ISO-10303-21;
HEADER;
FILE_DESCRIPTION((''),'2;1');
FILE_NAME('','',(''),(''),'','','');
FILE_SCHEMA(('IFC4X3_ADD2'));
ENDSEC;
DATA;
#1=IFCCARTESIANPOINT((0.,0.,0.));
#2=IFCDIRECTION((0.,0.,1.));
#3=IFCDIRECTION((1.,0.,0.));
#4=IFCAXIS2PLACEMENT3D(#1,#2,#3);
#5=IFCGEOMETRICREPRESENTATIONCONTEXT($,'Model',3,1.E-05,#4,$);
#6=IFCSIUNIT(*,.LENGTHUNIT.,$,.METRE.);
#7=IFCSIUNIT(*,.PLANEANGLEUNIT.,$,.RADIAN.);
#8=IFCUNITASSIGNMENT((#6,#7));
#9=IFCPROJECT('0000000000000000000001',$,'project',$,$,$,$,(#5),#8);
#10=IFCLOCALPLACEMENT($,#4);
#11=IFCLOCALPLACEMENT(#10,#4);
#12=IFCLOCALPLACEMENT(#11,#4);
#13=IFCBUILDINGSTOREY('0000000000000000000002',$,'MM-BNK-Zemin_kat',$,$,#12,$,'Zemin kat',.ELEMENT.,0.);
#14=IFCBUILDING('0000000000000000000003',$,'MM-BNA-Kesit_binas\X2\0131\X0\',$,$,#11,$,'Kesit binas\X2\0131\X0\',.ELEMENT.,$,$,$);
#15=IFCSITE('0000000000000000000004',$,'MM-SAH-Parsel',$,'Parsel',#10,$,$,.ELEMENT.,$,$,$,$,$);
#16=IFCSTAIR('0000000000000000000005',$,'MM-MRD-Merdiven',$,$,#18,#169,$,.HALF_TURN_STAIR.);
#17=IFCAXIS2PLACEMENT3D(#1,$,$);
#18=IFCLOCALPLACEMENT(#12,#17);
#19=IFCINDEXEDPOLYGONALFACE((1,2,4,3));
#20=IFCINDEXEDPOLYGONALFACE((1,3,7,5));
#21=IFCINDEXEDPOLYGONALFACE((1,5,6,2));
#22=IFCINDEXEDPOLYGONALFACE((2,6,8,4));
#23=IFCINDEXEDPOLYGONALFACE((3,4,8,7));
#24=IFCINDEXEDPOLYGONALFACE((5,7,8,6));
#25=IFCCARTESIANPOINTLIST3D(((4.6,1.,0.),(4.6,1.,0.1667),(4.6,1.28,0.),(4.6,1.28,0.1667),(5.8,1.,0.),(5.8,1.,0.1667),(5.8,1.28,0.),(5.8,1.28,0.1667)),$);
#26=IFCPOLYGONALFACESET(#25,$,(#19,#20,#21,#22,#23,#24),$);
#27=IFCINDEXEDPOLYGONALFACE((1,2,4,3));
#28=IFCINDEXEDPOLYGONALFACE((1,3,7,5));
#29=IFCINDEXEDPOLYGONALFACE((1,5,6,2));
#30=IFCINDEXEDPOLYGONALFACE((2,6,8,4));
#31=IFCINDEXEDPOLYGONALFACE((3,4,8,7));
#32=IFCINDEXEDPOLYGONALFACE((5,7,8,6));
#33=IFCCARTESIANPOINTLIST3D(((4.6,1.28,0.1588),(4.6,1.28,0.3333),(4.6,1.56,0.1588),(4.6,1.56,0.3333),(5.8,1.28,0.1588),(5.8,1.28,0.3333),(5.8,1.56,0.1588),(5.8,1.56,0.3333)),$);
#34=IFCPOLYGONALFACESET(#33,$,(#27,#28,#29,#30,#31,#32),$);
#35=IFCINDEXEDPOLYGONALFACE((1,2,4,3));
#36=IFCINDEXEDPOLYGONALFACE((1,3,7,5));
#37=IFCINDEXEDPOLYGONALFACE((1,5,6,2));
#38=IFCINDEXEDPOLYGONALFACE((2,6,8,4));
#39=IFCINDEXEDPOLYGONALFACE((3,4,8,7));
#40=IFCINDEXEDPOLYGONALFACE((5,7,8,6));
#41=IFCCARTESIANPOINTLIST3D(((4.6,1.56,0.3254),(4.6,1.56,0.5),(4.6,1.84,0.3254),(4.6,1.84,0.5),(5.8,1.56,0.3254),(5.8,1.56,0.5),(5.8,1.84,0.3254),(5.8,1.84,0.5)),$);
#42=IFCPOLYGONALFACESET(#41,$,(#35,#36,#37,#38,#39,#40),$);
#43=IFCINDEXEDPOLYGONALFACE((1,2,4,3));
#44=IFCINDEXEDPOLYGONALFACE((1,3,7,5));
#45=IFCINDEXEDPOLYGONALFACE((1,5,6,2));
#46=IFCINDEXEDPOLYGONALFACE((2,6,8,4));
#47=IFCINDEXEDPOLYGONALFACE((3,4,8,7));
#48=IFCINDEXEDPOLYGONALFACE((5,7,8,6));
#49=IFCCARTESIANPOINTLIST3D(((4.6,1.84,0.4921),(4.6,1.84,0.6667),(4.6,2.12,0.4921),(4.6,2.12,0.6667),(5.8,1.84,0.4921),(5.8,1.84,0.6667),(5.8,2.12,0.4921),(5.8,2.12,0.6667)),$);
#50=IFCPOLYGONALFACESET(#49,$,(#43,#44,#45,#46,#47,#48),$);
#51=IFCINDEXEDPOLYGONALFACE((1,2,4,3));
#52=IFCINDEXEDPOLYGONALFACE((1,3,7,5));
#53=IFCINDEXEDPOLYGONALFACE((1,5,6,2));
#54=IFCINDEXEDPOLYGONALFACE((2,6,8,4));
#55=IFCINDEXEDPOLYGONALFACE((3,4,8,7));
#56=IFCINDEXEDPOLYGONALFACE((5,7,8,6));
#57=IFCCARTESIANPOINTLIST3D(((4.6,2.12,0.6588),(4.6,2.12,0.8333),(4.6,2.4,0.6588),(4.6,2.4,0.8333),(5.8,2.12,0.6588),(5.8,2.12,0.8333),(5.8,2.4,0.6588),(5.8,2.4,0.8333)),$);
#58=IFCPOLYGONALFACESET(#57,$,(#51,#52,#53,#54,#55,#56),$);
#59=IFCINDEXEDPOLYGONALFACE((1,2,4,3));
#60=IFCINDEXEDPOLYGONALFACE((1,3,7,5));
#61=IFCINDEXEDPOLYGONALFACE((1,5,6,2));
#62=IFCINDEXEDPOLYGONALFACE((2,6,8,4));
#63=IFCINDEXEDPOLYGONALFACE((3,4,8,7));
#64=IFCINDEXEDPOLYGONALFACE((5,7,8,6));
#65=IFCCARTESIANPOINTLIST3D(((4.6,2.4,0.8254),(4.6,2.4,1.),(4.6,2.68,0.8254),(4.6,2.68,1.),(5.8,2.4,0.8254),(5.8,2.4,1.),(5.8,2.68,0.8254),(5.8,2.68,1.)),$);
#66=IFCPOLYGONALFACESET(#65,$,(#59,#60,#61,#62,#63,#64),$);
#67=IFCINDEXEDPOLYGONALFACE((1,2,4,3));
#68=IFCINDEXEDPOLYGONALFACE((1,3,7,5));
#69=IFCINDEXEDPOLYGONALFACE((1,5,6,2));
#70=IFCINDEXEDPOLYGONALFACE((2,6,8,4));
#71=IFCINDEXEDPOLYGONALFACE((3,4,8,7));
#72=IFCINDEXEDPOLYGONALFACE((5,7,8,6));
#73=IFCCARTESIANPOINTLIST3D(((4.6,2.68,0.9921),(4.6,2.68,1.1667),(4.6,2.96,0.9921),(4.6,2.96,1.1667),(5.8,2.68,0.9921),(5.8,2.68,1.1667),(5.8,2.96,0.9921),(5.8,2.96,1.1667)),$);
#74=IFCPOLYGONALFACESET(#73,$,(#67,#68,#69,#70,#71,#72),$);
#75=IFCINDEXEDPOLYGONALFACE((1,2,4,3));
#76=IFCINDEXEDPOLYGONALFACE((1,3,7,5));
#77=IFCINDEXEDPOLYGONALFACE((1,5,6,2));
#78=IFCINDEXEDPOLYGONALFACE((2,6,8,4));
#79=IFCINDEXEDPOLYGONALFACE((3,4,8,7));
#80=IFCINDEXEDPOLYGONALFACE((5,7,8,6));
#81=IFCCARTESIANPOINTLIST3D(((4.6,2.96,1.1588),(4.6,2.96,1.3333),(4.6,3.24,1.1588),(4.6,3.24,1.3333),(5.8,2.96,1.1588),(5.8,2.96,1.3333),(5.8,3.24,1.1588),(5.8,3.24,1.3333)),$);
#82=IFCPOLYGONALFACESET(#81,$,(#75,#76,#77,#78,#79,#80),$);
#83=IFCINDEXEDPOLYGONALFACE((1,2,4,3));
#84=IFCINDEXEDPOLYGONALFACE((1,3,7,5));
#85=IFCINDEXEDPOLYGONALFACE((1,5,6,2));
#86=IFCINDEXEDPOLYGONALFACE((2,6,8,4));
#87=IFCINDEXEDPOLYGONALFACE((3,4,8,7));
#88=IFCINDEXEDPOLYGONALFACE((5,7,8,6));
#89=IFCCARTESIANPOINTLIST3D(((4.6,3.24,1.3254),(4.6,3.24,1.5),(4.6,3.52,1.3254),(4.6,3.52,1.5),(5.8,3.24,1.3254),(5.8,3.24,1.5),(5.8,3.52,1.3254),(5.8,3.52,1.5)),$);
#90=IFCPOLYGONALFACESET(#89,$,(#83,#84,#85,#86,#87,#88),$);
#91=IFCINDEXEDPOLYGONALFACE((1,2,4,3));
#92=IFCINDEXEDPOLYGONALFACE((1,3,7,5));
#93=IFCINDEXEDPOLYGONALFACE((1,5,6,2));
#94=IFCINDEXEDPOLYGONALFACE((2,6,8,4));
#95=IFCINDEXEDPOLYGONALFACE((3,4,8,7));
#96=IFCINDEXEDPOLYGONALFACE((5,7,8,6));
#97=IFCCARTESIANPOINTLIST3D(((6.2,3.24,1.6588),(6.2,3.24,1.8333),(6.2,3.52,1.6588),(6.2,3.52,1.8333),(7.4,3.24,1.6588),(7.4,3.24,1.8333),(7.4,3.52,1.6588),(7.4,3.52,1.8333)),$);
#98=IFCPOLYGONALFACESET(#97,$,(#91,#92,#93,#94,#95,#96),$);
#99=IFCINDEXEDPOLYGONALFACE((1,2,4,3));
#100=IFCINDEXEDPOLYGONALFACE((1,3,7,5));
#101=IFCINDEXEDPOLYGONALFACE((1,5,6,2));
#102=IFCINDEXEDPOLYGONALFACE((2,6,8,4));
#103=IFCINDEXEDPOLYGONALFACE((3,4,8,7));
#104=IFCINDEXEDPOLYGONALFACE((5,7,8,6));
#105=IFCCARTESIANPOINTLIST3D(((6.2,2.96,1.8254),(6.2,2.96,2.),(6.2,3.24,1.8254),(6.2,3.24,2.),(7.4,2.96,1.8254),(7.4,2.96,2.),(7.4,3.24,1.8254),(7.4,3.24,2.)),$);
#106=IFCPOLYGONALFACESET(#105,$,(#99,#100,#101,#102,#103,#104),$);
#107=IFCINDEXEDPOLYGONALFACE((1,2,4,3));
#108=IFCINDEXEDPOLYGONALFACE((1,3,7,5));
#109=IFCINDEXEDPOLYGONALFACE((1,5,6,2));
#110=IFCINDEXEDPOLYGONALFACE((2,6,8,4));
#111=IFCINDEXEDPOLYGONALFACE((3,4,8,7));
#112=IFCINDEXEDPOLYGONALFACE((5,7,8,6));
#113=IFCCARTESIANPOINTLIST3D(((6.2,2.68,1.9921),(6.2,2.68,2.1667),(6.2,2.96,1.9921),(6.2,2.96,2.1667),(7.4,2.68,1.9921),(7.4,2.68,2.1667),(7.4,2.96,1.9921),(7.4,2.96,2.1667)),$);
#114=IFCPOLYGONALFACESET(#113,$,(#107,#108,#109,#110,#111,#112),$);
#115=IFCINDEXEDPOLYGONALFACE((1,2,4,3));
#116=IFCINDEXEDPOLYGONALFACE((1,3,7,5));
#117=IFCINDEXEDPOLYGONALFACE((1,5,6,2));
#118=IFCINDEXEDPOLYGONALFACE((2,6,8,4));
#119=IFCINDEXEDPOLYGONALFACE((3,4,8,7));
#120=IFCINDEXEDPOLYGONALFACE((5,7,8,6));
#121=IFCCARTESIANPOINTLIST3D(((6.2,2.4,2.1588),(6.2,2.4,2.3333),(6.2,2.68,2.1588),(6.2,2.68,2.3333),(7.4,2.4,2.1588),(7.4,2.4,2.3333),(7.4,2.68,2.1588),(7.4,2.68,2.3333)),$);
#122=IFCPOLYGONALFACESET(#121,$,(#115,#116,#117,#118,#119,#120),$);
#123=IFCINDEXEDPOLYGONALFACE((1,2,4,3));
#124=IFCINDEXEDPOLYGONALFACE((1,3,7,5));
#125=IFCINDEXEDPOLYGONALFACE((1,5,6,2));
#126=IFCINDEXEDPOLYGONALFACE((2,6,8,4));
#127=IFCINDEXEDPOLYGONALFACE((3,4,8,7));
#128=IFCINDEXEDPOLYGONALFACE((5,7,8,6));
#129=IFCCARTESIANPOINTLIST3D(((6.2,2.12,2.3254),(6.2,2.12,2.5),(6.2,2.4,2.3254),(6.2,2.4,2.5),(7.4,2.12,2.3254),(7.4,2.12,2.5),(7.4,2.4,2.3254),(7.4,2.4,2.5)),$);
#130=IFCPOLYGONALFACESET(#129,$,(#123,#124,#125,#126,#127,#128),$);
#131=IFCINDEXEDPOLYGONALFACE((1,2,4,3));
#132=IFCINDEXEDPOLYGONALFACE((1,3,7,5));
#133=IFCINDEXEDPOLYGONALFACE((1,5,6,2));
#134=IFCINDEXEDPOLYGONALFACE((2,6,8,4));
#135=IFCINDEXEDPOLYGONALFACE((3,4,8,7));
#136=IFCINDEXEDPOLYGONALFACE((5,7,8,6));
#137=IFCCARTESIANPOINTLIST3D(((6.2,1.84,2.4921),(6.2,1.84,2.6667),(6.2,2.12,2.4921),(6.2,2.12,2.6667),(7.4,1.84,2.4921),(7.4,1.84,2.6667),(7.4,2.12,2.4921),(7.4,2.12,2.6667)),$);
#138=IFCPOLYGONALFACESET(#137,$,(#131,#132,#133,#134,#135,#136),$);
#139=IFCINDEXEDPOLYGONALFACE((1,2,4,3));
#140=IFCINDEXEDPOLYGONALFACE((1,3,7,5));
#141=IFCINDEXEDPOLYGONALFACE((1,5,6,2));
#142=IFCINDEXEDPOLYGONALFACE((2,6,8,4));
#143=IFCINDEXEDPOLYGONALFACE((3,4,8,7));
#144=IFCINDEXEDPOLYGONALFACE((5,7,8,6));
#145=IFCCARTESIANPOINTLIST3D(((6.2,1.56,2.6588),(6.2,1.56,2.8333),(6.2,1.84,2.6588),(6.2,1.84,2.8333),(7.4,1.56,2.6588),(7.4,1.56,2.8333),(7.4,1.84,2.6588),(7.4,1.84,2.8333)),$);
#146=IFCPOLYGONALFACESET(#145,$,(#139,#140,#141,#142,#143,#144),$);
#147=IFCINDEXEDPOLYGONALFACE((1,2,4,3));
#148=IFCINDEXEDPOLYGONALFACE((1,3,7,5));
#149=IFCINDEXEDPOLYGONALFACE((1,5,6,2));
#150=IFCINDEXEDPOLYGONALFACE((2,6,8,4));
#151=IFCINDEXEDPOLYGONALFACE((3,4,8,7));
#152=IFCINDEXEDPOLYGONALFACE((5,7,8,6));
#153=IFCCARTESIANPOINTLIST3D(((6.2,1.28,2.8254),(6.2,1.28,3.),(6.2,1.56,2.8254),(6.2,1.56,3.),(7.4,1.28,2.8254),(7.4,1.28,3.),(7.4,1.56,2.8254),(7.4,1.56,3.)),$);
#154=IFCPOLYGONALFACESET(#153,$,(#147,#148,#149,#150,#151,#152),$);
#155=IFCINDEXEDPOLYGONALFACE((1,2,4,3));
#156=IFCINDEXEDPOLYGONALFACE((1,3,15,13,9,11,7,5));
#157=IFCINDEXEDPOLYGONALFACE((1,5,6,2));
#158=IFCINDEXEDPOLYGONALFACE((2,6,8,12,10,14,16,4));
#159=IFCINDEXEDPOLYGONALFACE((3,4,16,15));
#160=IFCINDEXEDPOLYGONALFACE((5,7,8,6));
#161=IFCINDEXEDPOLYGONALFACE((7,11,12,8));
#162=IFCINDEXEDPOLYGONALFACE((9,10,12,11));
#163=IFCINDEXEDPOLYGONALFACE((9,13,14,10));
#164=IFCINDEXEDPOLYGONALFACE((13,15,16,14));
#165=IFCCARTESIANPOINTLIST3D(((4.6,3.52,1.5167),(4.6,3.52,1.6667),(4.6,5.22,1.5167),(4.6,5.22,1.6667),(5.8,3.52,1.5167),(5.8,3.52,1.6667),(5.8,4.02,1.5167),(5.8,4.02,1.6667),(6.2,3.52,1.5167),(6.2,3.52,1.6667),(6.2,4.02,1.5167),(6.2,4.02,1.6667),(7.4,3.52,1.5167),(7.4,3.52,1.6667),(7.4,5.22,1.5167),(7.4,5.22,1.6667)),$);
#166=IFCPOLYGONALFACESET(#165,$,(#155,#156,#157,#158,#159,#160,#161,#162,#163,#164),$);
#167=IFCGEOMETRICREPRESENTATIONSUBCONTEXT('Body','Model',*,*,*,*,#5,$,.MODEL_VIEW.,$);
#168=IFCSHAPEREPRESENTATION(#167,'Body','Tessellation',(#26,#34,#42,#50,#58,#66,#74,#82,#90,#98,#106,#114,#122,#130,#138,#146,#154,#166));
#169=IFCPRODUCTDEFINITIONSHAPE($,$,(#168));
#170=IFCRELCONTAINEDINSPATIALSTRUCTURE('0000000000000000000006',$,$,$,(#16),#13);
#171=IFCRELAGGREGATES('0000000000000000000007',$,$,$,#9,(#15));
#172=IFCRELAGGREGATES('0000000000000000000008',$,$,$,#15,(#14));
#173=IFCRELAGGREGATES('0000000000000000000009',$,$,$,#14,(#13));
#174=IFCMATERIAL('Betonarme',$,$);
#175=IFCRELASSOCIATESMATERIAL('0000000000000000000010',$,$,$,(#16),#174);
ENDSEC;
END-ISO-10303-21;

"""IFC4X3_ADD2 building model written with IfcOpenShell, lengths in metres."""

from ifc_helpers import new_model, si_unit, frame, origin, origin_with_axes, place, context, subcontext, project, spatial, polyline, outline, extrude, material, element, save


model = new_model("IFC4X3_ADD2")

# Units and contexts
model_context = context("Model", 3, precision=1e-05, world=origin_with_axes())
body_context = subcontext(model_context, "Body", "Model", "MODEL_VIEW")
ifc_project = project(units=[si_unit("LENGTHUNIT", "METRE"), si_unit("PLANEANGLEUNIT", "RADIAN")], contexts=[model_context])

# Site, building, storey
site_placement = place(None, origin_with_axes())
site = spatial("IfcSite", under=ifc_project, at=site_placement, Name="MM-SAH-Parsel", ObjectType="Parsel", CompositionType="ELEMENT")
building_placement = place(site_placement, origin_with_axes())
building = spatial("IfcBuilding", under=site, at=building_placement, Name="MM-BNA-Kesit_binası", LongName="Kesit binası", CompositionType="ELEMENT")
storey_placement = place(building_placement, origin_with_axes())
storey = spatial("IfcBuildingStorey", under=building, at=storey_placement, Name="MM-BNK-Zemin_kat", LongName="Zemin kat", CompositionType="ELEMENT", Elevation=0.0)

# Shared definitions
ifc_material_1 = material(Name="Betonarme")

# Stair
stair_placement = place(storey_placement, origin_with_axes())
element("IfcStair", 1, at=stair_placement, inside=storey, material=ifc_material_1, Name="MM-MRD-Merdiven", PredefinedType="HALF_TURN_STAIR", context=body_context, shape_type="SweptSolid", body=[
    extrude(outline(polyline([(5.8, 1.0), (5.8, 1.28), (4.6, 1.28), (4.6, 1.0), (5.8, 1.0)])), origin(), (0.0, 0.0, 1.0), 0.1667),
    extrude(outline(polyline([(5.8, 1.28), (5.8, 1.56), (4.6, 1.56), (4.6, 1.28), (5.8, 1.28)])), frame((0.0, 0.0, 0.1588)), (0.0, 0.0, 1.0), 0.1746),
    extrude(outline(polyline([(5.8, 1.56), (5.8, 1.84), (4.6, 1.84), (4.6, 1.56), (5.8, 1.56)])), frame((0.0, 0.0, 0.3254)), (0.0, 0.0, 1.0), 0.1746),
    extrude(outline(polyline([(5.8, 1.84), (5.8, 2.12), (4.6, 2.12), (4.6, 1.84), (5.8, 1.84)])), frame((0.0, 0.0, 0.4921)), (0.0, 0.0, 1.0), 0.1746),
    extrude(outline(polyline([(5.8, 2.12), (5.8, 2.4), (4.6, 2.4), (4.6, 2.12), (5.8, 2.12)])), frame((0.0, 0.0, 0.6588)), (0.0, 0.0, 1.0), 0.1746),
    extrude(outline(polyline([(5.8, 2.4), (5.8, 2.68), (4.6, 2.68), (4.6, 2.4), (5.8, 2.4)])), frame((0.0, 0.0, 0.8254)), (0.0, 0.0, 1.0), 0.1746),
    extrude(outline(polyline([(5.8, 2.68), (5.8, 2.96), (4.6, 2.96), (4.6, 2.68), (5.8, 2.68)])), frame((0.0, 0.0, 0.9921)), (0.0, 0.0, 1.0), 0.1746),
    extrude(outline(polyline([(5.8, 2.96), (5.8, 3.24), (4.6, 3.24), (4.6, 2.96), (5.8, 2.96)])), frame((0.0, 0.0, 1.1588)), (0.0, 0.0, 1.0), 0.1746),
    extrude(outline(polyline([(5.8, 3.24), (5.8, 3.52), (4.6, 3.52), (4.6, 3.24), (5.8, 3.24)])), frame((0.0, 0.0, 1.3254)), (0.0, 0.0, 1.0), 0.1746),
    extrude(outline(polyline([(6.2, 3.52), (6.2, 3.24), (7.4, 3.24), (7.4, 3.52), (6.2, 3.52)])), frame((0.0, 0.0, 1.6588)), (0.0, 0.0, 1.0), 0.1746),
    extrude(outline(polyline([(6.2, 3.24), (6.2, 2.96), (7.4, 2.96), (7.4, 3.24), (6.2, 3.24)])), frame((0.0, 0.0, 1.8254)), (0.0, 0.0, 1.0), 0.1746),
    extrude(outline(polyline([(6.2, 2.96), (6.2, 2.68), (7.4, 2.68), (7.4, 2.96), (6.2, 2.96)])), frame((0.0, 0.0, 1.9921)), (0.0, 0.0, 1.0), 0.1746),
    extrude(outline(polyline([(6.2, 2.68), (6.2, 2.4), (7.4, 2.4), (7.4, 2.68), (6.2, 2.68)])), frame((0.0, 0.0, 2.1588)), (0.0, 0.0, 1.0), 0.1746),
    extrude(outline(polyline([(6.2, 2.4), (6.2, 2.12), (7.4, 2.12), (7.4, 2.4), (6.2, 2.4)])), frame((0.0, 0.0, 2.3254)), (0.0, 0.0, 1.0), 0.1746),
    extrude(outline(polyline([(6.2, 2.12), (6.2, 1.84), (7.4, 1.84), (7.4, 2.12), (6.2, 2.12)])), frame((0.0, 0.0, 2.4921)), (0.0, 0.0, 1.0), 0.1746),
    extrude(outline(polyline([(6.2, 1.84), (6.2, 1.56), (7.4, 1.56), (7.4, 1.84), (6.2, 1.84)])), frame((0.0, 0.0, 2.6588)), (0.0, 0.0, 1.0), 0.1746),
    extrude(outline(polyline([(6.2, 1.56), (6.2, 1.28), (7.4, 1.28), (7.4, 1.56), (6.2, 1.56)])), frame((0.0, 0.0, 2.8254)), (0.0, 0.0, 1.0), 0.1746),
    extrude(outline(polyline([(4.6, 3.52), (4.6, 5.22), (7.4, 5.22), (7.4, 3.52), (6.2, 3.52), (6.2, 4.02), (5.8, 4.02), (5.8, 3.52), (4.6, 3.52)])), frame((0.0, 0.0, 1.5167)), (0.0, 0.0, 1.0), 0.15),
])

save(model, "model.ifc")
